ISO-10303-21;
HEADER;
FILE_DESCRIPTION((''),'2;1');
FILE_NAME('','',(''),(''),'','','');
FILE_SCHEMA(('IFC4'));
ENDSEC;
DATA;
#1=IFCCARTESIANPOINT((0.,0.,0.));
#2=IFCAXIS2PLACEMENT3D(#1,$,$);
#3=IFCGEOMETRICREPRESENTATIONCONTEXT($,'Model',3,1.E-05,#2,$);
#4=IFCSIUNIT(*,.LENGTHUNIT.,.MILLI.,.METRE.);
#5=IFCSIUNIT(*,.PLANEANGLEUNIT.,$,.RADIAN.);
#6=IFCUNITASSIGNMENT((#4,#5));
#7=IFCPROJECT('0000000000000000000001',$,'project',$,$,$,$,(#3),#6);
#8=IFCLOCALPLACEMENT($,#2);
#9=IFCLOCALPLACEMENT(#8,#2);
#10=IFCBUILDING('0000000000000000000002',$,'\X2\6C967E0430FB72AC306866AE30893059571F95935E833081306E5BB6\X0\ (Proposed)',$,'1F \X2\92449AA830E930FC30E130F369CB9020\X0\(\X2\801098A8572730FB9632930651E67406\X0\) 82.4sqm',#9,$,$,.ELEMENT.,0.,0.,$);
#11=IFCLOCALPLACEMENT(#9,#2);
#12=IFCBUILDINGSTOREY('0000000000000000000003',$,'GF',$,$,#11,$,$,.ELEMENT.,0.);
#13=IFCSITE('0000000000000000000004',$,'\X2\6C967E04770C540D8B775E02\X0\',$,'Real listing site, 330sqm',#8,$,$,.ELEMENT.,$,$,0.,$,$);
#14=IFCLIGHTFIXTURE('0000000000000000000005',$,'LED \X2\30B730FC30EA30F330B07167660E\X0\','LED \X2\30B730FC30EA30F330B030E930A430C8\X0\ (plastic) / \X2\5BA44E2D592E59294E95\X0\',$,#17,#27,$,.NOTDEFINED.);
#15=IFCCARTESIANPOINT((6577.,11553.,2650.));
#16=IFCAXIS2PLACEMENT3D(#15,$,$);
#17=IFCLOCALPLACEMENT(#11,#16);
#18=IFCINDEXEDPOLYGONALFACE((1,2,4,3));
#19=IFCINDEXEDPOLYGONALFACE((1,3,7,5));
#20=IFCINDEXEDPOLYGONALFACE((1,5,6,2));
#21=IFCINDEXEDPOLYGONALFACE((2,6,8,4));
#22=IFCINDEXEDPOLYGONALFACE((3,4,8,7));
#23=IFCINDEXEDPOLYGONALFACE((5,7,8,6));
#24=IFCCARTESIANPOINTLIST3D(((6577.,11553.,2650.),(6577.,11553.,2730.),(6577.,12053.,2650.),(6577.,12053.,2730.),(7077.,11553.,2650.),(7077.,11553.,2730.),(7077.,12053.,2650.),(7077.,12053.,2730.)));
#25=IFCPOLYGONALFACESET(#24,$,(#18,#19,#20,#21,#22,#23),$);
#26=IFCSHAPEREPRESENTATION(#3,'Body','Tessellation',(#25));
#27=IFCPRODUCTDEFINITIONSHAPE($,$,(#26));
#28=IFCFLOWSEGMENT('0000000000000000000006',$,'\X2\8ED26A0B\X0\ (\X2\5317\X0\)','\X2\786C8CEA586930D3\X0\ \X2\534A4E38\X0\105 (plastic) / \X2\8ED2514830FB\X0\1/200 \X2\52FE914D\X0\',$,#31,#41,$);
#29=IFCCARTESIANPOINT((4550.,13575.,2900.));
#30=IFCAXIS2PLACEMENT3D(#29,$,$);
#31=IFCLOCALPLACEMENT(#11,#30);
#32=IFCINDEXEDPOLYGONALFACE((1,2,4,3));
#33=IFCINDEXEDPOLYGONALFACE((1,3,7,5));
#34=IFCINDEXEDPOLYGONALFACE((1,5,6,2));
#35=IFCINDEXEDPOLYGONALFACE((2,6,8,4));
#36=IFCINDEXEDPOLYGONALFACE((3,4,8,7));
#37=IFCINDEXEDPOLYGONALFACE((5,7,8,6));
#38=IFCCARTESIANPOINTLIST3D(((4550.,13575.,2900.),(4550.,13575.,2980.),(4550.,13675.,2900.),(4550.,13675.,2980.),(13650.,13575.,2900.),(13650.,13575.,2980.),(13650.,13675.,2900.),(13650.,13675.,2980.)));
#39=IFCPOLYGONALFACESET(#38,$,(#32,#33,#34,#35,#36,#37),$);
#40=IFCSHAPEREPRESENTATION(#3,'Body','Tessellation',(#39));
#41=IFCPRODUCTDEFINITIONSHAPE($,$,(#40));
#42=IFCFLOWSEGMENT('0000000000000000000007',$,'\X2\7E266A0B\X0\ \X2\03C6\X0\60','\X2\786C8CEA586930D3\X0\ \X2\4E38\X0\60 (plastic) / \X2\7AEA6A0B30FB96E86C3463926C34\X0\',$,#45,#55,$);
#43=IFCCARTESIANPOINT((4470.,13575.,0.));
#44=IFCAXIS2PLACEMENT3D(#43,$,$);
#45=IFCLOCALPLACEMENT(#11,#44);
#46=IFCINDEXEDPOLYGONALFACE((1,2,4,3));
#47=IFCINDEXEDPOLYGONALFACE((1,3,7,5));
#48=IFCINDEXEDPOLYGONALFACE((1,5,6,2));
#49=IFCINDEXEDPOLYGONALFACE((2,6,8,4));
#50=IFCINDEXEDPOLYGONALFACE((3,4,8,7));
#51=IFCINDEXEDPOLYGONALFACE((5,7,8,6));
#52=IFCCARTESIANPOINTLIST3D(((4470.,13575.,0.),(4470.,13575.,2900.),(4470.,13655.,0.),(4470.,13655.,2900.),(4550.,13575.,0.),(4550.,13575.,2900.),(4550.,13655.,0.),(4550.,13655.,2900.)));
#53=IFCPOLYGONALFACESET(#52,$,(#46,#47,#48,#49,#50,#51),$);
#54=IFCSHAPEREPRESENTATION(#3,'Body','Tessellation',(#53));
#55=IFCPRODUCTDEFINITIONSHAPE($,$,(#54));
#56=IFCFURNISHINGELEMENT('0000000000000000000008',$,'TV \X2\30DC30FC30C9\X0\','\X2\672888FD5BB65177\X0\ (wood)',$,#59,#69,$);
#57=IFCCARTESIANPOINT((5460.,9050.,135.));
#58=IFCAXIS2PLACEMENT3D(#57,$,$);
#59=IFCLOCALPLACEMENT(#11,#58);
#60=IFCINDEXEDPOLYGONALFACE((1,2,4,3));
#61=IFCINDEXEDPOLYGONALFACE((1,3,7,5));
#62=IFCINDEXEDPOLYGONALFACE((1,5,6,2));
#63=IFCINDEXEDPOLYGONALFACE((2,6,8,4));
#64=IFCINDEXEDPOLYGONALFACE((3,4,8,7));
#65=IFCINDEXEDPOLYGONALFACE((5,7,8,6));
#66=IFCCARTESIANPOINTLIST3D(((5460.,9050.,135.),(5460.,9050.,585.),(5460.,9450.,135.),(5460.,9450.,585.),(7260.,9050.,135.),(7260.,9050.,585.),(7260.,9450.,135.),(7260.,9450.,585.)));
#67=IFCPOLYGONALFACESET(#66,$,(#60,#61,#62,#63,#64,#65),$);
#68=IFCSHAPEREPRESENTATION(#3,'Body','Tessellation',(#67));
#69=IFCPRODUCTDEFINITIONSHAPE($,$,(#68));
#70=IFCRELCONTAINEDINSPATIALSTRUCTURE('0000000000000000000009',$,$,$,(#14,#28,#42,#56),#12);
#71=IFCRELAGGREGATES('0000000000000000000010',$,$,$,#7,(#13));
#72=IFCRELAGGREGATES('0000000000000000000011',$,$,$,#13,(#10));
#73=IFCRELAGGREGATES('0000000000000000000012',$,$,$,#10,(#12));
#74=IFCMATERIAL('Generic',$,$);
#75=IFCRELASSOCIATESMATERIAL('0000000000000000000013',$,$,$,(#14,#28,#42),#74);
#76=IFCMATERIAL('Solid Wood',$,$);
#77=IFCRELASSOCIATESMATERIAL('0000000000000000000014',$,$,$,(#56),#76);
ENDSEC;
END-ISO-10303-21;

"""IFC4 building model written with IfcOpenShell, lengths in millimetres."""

from ifc_helpers import new_model, si_unit, frame, frame_2d, origin, place, context, project, spatial, rectangle, extrude, material, element, save


model = new_model("IFC4")

# Units and contexts
model_context = context("Model", 3, precision=1e-05, world=origin())
ifc_project = project(units=[si_unit("LENGTHUNIT", "METRE", prefix="MILLI"), si_unit("PLANEANGLEUNIT", "RADIAN")], contexts=[model_context])

# Site, building, storey
site_placement = place(None, origin())
site = spatial("IfcSite", under=ifc_project, at=site_placement, Name="沖縄県名護市", ObjectType="Real listing site, 330sqm", CompositionType="ELEMENT", RefElevation=0.0)
building_placement = place(site_placement, origin())
building = spatial("IfcBuilding", under=site, at=building_placement, Name="沖縄・犬と暮らす土間広めの家 (Proposed)", ObjectType="1F 鉄骨ラーメン構造(耐風圧・防錆処理) 82.4sqm", CompositionType="ELEMENT", ElevationOfRefHeight=0.0, ElevationOfTerrain=0.0)
storey_placement = place(building_placement, origin())
storey = spatial("IfcBuildingStorey", under=building, at=storey_placement, Name="GF", CompositionType="ELEMENT", Elevation=0.0)

# Shared definitions
ifc_material_1 = material(Name="Solid Wood")

# Shared definitions
ifc_material_2 = material(Name="Generic")

# Light fixture
light_fixture_placement = place(storey_placement, frame((6577.0, 11553.0, 2650.0)))
element("IfcLightFixture", 1, at=light_fixture_placement, inside=storey, material=ifc_material_2, Name="LED シーリング照明", Description="LED シーリングライト (plastic) / 室中央天井", PredefinedType="NOTDEFINED", context=model_context, shape_type="SweptSolid", body=[
    extrude(rectangle(XDim=500.0, YDim=500.0, at=frame_2d((250.0, 250.0))), frame((6577.0, 11553.0, 2650.0)), (0.0, 0.0, 1.0), 80.0),
])

# Flow segments
flow_segment_1_placement = place(storey_placement, frame((4550.0, 13575.0, 2900.0)))
element("IfcFlowSegment", 2, at=flow_segment_1_placement, inside=storey, material=ifc_material_2, Name="軒樋 (北)", Description="硬質塩ビ 半丸105 (plastic) / 軒先・1/200 勾配", context=model_context, shape_type="SweptSolid", body=[
    extrude(rectangle(XDim=9100.0, YDim=100.0, at=frame_2d((4550.0, 50.0))), frame((4550.0, 13575.0, 2900.0)), (0.0, 0.0, 1.0), 80.0),
])
flow_segment_2_placement = place(storey_placement, frame((4470.0, 13575.0, 0.0)))
element("IfcFlowSegment", 3, at=flow_segment_2_placement, inside=storey, material=ifc_material_2, Name="縦樋 φ60", Description="硬質塩ビ 丸60 (plastic) / 竪樋・雨水排水", context=model_context, shape_type="SweptSolid", body=[
    extrude(rectangle(XDim=80.0, YDim=80.0, at=frame_2d((40.0, 40.0))), frame((4470.0, 13575.0, 0.0)), (0.0, 0.0, 1.0), 2900.0),
])

# Furnishing element
furnishing_placement = place(storey_placement, frame((5460.0, 9050.0, 135.0)))
element("IfcFurnishingElement", 4, at=furnishing_placement, inside=storey, material=ifc_material_1, Name="TV ボード", Description="木製家具 (wood)", context=model_context, shape_type="SweptSolid", body=[
    extrude(rectangle(XDim=1800.0, YDim=400.0, at=frame_2d((900.0, 200.0))), frame((5460.0, 9050.0, 135.0)), (0.0, 0.0, 1.0), 450.0),
])

save(model, "model.ifc")
